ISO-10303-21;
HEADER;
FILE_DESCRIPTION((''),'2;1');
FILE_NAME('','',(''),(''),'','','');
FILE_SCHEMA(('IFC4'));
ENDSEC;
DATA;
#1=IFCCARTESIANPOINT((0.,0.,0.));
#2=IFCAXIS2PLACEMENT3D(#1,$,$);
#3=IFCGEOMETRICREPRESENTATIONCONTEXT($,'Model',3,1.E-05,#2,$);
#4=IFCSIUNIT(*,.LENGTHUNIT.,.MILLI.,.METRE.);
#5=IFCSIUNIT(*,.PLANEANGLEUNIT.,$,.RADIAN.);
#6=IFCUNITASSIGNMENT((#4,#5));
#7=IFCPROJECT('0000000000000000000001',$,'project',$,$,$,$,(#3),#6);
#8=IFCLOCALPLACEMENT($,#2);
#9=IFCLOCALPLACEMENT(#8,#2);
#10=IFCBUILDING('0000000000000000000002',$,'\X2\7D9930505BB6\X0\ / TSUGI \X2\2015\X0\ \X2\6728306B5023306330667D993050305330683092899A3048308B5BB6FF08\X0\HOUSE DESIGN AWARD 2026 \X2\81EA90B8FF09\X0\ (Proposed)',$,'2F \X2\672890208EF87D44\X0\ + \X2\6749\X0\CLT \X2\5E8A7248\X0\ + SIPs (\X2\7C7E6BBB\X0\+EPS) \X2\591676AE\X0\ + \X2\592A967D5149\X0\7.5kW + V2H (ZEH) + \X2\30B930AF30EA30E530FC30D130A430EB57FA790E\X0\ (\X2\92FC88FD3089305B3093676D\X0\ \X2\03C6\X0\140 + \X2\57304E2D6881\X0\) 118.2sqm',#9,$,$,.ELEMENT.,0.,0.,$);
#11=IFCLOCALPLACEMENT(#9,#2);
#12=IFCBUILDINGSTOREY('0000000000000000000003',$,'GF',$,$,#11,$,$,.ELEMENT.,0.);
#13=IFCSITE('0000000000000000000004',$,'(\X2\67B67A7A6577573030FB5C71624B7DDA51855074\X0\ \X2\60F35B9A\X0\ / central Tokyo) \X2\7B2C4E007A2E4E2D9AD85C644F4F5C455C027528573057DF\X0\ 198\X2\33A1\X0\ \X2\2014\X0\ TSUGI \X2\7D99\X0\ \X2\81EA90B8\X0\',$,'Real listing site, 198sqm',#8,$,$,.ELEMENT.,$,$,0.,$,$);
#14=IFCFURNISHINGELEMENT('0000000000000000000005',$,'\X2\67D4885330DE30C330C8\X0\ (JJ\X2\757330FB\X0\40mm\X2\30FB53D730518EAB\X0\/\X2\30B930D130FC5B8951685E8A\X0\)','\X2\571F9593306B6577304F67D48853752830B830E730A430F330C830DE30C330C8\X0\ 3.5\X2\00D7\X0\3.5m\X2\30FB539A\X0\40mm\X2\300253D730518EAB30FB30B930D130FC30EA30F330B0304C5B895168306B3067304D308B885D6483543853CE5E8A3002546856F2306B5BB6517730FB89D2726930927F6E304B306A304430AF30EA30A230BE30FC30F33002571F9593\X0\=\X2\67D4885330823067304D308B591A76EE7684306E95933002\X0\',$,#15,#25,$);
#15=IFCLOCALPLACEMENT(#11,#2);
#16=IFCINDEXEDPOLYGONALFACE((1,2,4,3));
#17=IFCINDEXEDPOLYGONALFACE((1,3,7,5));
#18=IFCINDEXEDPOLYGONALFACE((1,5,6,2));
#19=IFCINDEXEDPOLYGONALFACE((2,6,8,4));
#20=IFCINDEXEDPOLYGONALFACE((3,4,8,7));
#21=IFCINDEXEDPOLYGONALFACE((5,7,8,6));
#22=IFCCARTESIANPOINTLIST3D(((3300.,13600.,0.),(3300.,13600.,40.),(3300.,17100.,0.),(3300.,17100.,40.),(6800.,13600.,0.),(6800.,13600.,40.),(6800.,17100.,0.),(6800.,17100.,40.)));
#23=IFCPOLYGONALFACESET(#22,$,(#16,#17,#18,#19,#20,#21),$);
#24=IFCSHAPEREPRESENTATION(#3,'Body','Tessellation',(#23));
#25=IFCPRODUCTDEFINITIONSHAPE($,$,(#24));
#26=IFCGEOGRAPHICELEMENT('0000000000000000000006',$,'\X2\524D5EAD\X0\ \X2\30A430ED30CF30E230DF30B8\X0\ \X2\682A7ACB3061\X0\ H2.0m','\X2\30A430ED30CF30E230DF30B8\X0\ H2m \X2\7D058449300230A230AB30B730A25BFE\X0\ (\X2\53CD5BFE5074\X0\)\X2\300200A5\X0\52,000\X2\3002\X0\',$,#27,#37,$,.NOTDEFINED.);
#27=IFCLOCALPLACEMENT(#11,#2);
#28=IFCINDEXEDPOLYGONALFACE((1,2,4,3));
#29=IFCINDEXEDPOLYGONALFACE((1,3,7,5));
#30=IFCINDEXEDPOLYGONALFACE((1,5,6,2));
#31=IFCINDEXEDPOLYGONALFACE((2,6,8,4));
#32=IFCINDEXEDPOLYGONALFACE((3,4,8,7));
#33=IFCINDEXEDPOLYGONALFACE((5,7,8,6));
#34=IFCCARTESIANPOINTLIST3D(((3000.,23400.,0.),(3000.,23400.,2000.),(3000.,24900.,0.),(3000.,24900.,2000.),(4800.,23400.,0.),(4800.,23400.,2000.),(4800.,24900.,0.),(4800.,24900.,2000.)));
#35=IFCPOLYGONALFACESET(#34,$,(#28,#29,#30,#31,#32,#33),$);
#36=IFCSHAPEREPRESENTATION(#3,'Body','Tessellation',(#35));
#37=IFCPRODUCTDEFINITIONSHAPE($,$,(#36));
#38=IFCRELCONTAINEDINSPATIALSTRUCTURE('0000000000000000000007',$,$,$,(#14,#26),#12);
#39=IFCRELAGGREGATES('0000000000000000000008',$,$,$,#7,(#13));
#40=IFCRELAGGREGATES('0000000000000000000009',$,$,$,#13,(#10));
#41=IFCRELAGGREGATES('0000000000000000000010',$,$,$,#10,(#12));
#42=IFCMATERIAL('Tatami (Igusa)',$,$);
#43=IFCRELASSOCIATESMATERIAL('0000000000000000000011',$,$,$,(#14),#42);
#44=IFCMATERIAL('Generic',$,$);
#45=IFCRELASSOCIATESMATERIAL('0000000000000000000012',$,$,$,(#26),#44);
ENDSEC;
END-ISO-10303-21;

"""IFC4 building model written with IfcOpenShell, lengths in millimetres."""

from ifc_helpers import new_model, si_unit, frame, frame_2d, origin, place, context, project, spatial, rectangle, extrude, material, element, save


model = new_model("IFC4")

# Units and contexts
model_context = context("Model", 3, precision=1e-05, world=origin())
ifc_project = project(units=[si_unit("LENGTHUNIT", "METRE", prefix="MILLI"), si_unit("PLANEANGLEUNIT", "RADIAN")], contexts=[model_context])

# Site, building, storey
site_placement = place(None, origin())
site = spatial("IfcSite", under=ifc_project, at=site_placement, Name="(架空敷地・山手線内側 想定 / central Tokyo) 第一種中高層住居専用地域 198㎡ — TSUGI 継 自邸", ObjectType="Real listing site, 198sqm", CompositionType="ELEMENT", RefElevation=0.0)
building_placement = place(site_placement, origin())
building = spatial("IfcBuilding", under=site, at=building_placement, Name="継ぐ家 / TSUGI ― 木に倣って継ぐことを覚える家（HOUSE DESIGN AWARD 2026 自邸） (Proposed)", ObjectType="2F 木造軸組 + 杉CLT 床版 + SIPs (籾殻+EPS) 外皮 + 太陽光7.5kW + V2H (ZEH) + スクリューパイル基礎 (鋼製らせん杭 φ140 + 地中梁) 118.2sqm", CompositionType="ELEMENT", ElevationOfRefHeight=0.0, ElevationOfTerrain=0.0)
storey_placement = place(building_placement, origin())
storey = spatial("IfcBuildingStorey", under=building, at=storey_placement, Name="GF", CompositionType="ELEMENT", Elevation=0.0)

# Shared definitions
ifc_material_1 = material(Name="Generic")

# Furnishing element
ifc_material_2 = material(Name="Tatami (Igusa)")
furnishing_1_placement = place(storey_placement, frame((1650.0, 6800.0, 0.0)))
element("IfcFurnishingElement", 1, at=furnishing_1_placement, inside=storey, material=ifc_material_2, Name="柔術マット (JJ畳・40mm・受け身/スパー安全床)", Description="土間に敷く柔術用ジョイントマット 3.5×3.5m・厚40mm。受け身・スパーリングが安全にできる衝撃吸収床。周囲に家具・角物を置かないクリアゾーン。土間=柔術もできる多目的の間。", context=model_context, shape_type="SweptSolid", body=[
    extrude(rectangle(XDim=3500.0, YDim=3500.0, at=frame_2d((1750.0, 1750.0))), frame((1650.0, 6800.0, 0.0)), (0.0, 0.0, 1.0), 40.0),
])

# Geographic element
geographic_element_1_placement = place(storey_placement, frame((1500.0, 11700.0, 0.0)))
element("IfcGeographicElement", 2, at=geographic_element_1_placement, inside=storey, material=ifc_material_1, Name="前庭 イロハモミジ 株立ち H2.0m", Description="イロハモミジ H2m 紅葉。アカシア対 (反対側)。¥52,000。", PredefinedType="NOTDEFINED", context=model_context, shape_type="SweptSolid", body=[
    extrude(rectangle(XDim=1800.0, YDim=1500.0, at=frame_2d((900.0, 750.0))), frame((1500.0, 11700.0, 0.0)), (0.0, 0.0, 1.0), 2000.0),
])

save(model, "model.ifc")
